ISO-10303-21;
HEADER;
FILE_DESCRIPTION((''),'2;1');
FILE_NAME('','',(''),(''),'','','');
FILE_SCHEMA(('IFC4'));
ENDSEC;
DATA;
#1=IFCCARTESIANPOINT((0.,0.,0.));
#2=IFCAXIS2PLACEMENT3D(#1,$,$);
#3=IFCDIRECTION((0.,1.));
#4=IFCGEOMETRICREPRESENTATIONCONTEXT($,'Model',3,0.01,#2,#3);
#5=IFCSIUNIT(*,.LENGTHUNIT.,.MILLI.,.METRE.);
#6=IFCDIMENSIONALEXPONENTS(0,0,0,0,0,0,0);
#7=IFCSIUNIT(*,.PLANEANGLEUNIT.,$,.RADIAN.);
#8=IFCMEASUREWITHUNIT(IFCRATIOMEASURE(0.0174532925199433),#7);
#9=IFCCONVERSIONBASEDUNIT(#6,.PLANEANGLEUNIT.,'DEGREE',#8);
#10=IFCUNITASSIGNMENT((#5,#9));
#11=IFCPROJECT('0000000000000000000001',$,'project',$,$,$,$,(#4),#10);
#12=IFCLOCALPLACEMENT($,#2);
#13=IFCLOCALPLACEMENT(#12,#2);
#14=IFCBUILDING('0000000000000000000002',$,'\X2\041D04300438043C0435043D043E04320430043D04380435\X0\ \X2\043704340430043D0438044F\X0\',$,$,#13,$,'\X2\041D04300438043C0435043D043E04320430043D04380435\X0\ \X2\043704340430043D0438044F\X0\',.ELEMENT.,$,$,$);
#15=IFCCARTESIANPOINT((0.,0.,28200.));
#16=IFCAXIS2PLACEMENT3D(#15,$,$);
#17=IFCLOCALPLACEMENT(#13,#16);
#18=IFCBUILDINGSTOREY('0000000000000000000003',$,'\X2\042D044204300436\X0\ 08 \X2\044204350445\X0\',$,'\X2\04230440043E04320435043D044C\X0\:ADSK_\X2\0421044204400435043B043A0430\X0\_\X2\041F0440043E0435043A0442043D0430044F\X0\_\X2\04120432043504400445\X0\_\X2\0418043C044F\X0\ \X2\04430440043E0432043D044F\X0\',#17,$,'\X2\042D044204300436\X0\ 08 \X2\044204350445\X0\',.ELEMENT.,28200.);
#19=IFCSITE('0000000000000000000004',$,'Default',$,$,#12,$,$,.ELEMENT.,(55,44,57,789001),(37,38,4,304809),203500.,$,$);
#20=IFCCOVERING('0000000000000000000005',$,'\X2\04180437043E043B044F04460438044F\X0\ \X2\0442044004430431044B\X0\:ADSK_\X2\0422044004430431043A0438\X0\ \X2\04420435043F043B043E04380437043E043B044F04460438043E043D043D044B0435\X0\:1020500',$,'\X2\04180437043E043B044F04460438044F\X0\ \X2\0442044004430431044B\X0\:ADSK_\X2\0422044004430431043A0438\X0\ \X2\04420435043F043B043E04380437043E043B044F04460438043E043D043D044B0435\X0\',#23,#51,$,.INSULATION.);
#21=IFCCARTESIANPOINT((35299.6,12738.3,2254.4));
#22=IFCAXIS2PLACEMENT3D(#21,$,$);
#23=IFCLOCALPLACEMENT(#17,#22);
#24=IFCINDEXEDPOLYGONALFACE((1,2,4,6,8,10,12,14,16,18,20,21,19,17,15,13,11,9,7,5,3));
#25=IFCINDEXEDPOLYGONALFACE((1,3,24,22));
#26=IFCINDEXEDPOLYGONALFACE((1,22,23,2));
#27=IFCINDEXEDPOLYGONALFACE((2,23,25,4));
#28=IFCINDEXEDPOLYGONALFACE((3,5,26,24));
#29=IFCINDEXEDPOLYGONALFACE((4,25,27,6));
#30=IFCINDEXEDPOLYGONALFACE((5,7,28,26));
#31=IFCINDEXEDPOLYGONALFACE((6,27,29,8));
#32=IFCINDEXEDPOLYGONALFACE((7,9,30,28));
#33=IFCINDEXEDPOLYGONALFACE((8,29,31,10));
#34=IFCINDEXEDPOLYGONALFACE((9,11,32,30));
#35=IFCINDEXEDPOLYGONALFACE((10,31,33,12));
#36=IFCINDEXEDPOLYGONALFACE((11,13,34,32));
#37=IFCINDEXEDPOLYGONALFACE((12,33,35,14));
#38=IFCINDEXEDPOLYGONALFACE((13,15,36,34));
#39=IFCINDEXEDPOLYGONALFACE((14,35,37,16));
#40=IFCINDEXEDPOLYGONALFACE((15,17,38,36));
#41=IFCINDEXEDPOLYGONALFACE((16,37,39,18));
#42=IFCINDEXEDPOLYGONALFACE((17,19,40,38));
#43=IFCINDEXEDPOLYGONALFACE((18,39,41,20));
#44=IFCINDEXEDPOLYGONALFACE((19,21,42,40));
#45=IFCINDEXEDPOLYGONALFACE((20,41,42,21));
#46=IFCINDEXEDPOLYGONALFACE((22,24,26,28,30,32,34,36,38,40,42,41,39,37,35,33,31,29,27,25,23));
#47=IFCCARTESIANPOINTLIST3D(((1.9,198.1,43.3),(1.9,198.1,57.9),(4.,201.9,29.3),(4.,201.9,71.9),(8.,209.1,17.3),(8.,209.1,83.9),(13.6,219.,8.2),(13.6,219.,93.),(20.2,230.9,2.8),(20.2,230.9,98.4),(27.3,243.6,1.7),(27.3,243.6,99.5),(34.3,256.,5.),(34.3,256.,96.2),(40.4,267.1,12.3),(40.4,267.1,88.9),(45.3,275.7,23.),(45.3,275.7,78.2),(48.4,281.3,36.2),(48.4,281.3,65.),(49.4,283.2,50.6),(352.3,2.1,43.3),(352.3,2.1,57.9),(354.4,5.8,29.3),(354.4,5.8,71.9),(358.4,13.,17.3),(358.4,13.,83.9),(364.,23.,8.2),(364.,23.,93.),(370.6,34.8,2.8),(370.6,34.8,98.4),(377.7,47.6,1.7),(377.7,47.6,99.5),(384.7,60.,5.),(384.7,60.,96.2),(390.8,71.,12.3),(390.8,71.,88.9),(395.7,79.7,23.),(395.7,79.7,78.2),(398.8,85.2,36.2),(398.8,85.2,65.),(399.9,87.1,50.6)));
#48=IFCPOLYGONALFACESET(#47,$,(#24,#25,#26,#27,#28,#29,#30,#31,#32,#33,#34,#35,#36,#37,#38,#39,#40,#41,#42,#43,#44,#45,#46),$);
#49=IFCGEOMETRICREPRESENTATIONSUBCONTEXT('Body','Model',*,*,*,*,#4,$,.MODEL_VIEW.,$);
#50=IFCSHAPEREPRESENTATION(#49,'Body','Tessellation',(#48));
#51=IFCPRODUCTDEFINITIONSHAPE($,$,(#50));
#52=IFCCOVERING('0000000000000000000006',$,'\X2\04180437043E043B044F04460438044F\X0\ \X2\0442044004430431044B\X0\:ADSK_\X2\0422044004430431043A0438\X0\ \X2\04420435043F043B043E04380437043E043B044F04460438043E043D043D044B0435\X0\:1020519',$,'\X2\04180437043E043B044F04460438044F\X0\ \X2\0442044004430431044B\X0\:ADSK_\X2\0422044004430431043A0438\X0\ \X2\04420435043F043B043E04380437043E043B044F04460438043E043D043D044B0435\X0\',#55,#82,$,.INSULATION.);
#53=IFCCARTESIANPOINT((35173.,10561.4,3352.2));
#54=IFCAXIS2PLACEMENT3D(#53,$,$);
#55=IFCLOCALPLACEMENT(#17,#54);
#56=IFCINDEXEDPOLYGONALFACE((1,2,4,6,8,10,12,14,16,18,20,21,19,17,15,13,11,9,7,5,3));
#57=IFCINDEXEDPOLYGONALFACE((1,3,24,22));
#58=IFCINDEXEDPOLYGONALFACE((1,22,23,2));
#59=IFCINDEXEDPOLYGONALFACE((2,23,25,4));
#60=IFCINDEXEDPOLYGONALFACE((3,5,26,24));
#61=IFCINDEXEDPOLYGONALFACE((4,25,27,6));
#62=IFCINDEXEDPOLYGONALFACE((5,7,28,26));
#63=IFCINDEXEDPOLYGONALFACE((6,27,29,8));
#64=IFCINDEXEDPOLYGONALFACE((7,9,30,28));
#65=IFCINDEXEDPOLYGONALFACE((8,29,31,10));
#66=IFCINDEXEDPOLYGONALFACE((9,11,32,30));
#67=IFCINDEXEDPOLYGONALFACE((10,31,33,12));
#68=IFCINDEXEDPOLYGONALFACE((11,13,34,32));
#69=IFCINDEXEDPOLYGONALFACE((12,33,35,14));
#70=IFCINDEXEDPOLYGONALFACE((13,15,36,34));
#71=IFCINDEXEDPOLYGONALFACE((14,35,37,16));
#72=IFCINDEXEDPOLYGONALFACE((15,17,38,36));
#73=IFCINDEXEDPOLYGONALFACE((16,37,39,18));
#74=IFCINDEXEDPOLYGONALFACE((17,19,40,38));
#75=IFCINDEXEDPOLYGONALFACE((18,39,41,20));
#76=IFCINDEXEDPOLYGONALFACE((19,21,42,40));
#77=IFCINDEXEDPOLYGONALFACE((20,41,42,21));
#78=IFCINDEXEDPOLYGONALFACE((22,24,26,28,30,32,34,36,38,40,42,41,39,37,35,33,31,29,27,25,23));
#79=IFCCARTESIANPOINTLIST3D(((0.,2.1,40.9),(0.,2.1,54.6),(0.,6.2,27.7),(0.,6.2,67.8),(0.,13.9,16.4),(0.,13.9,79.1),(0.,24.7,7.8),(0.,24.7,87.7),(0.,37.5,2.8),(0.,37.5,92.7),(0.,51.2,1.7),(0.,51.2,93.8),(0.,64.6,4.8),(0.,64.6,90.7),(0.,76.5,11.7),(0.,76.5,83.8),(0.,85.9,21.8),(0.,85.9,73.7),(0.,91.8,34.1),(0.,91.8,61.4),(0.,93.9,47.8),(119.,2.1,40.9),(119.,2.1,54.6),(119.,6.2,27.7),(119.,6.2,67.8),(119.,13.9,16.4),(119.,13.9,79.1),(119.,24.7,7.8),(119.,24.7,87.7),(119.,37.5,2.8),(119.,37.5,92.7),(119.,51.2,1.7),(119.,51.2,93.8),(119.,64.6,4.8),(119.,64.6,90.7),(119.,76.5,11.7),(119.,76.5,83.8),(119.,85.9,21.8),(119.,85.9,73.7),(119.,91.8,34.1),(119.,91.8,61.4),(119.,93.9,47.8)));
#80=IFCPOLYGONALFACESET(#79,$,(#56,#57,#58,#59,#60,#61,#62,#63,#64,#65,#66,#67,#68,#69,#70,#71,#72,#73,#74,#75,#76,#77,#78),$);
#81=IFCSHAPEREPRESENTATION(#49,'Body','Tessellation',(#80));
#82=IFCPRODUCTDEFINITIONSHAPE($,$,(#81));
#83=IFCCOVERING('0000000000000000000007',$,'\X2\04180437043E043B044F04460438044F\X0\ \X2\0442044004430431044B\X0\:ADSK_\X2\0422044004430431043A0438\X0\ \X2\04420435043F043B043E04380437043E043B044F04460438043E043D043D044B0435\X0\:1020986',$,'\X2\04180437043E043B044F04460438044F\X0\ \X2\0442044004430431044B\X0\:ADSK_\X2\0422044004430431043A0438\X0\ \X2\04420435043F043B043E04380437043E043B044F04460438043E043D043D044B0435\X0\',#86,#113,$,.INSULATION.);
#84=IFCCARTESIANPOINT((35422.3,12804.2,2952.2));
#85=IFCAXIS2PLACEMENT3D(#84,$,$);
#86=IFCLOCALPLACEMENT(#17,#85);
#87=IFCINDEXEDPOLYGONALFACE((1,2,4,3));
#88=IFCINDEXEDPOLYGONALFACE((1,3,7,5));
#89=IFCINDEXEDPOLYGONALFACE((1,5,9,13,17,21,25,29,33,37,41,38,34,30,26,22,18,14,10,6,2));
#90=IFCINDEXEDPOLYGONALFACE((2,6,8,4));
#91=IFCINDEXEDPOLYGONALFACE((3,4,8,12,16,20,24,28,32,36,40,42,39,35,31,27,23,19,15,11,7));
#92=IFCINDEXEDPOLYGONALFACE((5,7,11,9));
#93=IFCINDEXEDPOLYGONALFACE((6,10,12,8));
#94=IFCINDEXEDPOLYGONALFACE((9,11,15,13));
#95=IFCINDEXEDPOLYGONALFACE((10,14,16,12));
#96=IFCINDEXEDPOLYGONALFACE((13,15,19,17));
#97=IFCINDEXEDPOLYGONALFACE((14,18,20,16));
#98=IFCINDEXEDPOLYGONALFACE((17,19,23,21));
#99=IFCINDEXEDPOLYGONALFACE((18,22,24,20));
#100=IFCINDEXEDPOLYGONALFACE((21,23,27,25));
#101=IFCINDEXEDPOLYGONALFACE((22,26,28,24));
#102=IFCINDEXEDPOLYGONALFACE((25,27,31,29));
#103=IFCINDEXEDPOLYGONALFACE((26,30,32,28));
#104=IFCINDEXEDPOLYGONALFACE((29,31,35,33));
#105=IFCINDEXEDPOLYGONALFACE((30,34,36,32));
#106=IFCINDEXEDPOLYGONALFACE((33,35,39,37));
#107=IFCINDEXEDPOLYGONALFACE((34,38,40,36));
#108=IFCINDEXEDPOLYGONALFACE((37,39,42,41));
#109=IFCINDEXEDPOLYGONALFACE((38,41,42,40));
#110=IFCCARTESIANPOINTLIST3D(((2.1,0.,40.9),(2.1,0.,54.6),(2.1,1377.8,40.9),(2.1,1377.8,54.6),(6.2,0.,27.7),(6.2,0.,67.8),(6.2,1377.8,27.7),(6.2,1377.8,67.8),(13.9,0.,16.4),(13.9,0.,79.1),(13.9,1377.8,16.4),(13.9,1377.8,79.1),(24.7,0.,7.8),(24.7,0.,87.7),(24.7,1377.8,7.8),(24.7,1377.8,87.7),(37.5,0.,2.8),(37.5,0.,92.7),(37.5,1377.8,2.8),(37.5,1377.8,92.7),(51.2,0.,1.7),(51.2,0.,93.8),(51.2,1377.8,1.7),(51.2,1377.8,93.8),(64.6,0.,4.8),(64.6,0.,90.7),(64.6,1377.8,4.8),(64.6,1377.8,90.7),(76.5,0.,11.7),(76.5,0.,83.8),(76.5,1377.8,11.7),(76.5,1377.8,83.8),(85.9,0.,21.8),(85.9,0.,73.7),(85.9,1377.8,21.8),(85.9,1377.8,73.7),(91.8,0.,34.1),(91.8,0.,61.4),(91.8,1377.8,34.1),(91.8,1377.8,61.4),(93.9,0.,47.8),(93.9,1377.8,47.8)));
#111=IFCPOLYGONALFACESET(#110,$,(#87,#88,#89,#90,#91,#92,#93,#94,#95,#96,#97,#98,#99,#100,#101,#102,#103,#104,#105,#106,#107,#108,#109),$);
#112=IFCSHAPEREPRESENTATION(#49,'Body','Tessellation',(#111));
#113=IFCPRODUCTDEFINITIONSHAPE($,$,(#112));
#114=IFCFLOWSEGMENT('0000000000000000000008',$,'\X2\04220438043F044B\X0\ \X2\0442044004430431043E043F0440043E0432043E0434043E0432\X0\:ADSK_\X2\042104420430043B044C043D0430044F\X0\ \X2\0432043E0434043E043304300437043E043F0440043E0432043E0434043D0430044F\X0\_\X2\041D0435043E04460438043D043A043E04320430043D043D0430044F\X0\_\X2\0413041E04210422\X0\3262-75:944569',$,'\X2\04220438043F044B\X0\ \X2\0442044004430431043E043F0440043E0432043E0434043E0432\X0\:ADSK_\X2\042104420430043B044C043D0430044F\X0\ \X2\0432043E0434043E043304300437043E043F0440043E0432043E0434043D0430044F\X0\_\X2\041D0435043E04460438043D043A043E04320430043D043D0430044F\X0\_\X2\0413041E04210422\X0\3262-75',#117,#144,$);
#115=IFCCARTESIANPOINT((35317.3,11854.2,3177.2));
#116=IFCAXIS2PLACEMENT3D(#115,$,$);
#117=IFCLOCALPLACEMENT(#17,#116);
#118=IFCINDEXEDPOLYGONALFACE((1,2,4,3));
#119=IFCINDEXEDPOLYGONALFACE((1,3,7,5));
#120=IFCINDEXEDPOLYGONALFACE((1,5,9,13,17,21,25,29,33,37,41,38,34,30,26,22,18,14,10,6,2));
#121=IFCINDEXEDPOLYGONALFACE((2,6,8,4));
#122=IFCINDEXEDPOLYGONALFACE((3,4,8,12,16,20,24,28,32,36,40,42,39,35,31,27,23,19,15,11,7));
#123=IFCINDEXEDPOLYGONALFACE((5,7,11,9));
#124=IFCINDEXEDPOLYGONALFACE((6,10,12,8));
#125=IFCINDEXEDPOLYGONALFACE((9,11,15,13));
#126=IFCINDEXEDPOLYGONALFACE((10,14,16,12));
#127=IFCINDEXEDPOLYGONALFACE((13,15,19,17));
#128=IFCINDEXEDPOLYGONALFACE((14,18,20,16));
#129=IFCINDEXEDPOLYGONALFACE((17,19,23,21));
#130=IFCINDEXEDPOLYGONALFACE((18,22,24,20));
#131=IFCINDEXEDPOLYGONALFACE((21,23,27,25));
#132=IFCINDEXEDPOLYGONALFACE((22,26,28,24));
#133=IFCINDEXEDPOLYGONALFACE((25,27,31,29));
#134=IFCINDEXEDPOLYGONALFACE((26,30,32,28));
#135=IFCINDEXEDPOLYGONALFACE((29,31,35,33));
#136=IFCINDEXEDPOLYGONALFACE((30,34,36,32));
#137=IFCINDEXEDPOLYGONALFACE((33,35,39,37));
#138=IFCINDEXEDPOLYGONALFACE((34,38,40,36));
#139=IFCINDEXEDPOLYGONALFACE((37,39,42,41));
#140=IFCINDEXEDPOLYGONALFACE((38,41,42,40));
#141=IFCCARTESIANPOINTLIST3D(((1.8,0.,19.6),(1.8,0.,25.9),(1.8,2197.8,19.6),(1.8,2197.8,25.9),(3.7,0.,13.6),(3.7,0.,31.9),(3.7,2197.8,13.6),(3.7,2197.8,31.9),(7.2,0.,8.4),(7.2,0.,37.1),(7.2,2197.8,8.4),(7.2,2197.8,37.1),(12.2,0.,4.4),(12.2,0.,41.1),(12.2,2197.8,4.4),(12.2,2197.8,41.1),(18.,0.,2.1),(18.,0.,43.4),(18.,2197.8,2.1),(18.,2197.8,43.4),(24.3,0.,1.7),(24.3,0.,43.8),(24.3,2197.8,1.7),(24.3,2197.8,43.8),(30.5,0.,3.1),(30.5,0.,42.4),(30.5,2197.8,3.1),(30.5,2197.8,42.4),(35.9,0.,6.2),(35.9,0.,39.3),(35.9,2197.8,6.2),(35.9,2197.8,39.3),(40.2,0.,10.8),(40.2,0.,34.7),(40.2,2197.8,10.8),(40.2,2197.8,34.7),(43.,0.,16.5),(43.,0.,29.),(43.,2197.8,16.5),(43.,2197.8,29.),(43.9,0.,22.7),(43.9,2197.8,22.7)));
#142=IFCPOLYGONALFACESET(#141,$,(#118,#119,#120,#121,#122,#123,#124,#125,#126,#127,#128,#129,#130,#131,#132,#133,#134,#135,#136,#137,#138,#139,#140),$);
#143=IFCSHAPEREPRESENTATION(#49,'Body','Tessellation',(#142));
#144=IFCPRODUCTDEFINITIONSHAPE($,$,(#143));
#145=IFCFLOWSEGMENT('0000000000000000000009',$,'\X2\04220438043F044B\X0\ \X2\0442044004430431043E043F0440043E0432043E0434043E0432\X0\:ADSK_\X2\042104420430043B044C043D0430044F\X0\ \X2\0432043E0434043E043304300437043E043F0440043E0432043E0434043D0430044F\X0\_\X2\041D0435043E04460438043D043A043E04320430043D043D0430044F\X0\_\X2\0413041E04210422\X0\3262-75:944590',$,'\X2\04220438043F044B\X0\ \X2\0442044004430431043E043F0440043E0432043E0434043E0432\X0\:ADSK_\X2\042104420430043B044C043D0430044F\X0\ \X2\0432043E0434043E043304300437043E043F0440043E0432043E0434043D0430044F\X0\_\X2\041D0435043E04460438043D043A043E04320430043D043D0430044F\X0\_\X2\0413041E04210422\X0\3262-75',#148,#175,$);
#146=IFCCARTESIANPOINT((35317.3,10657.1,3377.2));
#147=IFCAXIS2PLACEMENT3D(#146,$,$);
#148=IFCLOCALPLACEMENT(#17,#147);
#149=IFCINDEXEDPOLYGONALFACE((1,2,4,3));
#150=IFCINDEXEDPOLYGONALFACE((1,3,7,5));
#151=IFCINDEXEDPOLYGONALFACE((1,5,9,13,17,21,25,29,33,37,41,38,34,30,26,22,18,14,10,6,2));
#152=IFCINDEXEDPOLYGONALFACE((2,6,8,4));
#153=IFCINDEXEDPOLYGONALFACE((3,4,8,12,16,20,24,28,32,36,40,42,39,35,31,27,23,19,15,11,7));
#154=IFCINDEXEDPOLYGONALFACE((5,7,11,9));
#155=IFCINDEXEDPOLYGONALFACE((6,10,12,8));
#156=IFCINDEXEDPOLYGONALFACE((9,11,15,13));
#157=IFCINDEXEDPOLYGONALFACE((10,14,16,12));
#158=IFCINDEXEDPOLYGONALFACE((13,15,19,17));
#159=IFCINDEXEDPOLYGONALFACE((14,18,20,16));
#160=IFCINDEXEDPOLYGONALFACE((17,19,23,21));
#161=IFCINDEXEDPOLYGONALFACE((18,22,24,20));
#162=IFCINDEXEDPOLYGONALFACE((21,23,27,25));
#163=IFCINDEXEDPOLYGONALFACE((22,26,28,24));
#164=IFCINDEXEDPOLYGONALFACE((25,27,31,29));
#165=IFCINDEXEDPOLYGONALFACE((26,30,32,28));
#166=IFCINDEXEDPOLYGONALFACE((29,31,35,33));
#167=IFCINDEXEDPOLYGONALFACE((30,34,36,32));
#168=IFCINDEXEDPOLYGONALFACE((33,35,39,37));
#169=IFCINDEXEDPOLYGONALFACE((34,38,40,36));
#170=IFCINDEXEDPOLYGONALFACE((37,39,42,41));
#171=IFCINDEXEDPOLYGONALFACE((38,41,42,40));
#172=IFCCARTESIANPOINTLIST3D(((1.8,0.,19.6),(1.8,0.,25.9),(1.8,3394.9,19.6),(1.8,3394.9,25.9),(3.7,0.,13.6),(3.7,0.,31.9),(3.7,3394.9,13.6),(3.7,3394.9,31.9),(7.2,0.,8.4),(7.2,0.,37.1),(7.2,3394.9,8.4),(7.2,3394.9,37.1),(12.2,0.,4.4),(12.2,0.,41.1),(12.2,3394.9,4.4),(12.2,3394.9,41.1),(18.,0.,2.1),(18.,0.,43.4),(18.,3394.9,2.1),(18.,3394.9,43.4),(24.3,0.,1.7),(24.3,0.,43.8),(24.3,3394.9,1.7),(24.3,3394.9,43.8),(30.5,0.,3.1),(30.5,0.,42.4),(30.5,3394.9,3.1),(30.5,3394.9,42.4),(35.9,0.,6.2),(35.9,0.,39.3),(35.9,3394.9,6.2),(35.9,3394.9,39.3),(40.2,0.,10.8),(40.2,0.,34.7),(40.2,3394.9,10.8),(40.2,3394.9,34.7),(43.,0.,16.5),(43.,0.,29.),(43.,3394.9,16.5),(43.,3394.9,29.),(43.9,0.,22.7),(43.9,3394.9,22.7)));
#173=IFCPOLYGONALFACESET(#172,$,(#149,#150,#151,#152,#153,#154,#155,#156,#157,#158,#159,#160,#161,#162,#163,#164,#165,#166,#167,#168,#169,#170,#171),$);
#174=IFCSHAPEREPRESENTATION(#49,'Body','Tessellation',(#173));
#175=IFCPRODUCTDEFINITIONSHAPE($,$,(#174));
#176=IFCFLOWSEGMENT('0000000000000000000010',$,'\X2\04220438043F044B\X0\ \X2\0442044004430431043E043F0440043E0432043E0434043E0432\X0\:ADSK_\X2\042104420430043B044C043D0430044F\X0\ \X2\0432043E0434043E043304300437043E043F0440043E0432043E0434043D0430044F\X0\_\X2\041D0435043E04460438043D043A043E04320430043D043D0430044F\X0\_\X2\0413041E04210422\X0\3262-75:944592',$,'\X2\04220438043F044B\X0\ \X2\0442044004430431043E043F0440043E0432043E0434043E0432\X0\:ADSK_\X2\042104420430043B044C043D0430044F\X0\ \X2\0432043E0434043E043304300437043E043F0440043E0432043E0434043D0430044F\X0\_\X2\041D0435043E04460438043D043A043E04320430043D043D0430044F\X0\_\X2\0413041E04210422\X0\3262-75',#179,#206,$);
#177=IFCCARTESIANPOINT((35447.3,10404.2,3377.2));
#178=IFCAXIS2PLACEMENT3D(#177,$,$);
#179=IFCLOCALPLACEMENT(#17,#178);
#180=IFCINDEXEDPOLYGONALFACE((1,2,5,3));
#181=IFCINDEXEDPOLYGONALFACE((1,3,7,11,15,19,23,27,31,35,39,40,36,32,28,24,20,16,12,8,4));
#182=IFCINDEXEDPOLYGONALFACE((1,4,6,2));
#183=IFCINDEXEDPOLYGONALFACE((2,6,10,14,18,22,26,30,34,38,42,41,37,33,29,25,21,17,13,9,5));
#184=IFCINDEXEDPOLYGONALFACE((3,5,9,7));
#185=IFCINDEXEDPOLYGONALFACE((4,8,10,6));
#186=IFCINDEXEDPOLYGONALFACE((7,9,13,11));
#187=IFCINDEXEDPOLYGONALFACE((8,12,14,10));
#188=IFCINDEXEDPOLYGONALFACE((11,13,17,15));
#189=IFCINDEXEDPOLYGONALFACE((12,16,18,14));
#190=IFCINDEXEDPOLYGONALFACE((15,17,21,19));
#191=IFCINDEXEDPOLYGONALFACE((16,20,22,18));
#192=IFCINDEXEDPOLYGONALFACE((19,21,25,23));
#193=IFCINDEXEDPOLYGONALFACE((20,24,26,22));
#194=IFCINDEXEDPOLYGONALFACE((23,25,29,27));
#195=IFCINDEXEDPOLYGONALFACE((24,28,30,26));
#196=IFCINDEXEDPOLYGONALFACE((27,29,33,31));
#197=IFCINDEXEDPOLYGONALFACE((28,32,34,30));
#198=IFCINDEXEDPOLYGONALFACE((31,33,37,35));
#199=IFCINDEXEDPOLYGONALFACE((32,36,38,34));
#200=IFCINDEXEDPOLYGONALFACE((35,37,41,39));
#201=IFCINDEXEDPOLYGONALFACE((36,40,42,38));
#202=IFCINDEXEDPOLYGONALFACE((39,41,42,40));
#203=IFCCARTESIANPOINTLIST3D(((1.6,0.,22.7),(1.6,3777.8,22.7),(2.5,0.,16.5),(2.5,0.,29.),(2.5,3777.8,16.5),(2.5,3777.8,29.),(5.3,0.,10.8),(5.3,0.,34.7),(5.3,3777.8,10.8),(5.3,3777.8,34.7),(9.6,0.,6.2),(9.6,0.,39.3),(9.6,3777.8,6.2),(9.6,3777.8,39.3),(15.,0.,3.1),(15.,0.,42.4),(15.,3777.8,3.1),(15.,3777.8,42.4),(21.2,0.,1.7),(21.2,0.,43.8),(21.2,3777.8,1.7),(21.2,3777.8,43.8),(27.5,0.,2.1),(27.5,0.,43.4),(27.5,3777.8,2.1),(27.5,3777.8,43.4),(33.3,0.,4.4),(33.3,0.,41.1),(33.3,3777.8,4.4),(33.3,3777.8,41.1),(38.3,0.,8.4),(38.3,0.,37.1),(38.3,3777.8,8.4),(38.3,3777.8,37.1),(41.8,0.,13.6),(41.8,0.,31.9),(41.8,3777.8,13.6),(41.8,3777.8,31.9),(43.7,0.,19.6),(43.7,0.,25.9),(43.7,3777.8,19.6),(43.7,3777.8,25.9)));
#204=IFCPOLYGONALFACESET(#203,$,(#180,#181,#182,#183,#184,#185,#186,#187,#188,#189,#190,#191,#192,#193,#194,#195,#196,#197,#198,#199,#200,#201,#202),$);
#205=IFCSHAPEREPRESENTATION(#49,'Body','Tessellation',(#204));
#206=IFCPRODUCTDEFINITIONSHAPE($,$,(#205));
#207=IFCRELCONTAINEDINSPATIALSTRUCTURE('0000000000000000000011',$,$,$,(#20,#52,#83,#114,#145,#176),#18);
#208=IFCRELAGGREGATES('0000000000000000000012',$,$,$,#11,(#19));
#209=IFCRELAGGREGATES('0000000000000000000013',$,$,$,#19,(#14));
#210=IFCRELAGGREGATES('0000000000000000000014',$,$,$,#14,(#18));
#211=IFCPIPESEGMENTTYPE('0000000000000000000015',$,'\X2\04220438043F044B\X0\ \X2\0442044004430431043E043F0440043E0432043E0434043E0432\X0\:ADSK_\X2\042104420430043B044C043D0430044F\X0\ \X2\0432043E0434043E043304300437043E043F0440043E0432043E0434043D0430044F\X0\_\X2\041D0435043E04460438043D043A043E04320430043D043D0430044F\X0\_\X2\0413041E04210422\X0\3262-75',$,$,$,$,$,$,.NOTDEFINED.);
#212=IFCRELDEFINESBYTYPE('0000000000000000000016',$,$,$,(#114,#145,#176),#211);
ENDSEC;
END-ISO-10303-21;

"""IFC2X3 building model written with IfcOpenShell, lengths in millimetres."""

from ifc_helpers import new_model, entity, si_unit, converted_unit, direction, frame, origin, origin_2d_with_axis, place, context, subcontext, project, spatial, circle, extrude, type_object, element, save


model = new_model("IFC2X3")

# Units and contexts
model_context = context("Model", 3, precision=0.01, world=origin(), true_north=direction((0.0, 1.0)))
body_context = subcontext(model_context, "Body", "Model", "MODEL_VIEW")
ifc_project = project(units=[si_unit("LENGTHUNIT", "METRE", prefix="MILLI"), converted_unit("PLANEANGLEUNIT", "DEGREE", entity("IfcRatioMeasure", 0.0174532925199433), si_unit("PLANEANGLEUNIT", "RADIAN"), dimensions=[0, 0, 0, 0, 0, 0, 0])], contexts=[model_context])

# Site, building, storey
site_placement = place(None, origin())
site = spatial("IfcSite", under=ifc_project, at=site_placement, Name="Default", CompositionType="ELEMENT", RefLatitude=(55, 44, 57, 789001), RefLongitude=(37, 38, 4, 304809), RefElevation=203500.0)
building_placement = place(site_placement, origin())
building = spatial("IfcBuilding", under=site, at=building_placement, Name="Наименование здания", LongName="Наименование здания", CompositionType="ELEMENT")
storey_placement = place(building_placement, frame((0.0, 0.0, 28200.0)))
storey = spatial("IfcBuildingStorey", under=building, at=storey_placement, Name="Этаж 08 тех", ObjectType="Уровень:ADSK_Стрелка_Проектная_Вверх_Имя уровня", LongName="Этаж 08 тех", CompositionType="ELEMENT", Elevation=28200.0)

# Coverings
covering_1_placement = place(storey_placement, frame((35299.6, 12738.3, 2254.4)))
element("IfcCovering", 1, at=covering_1_placement, inside=storey, Name="Изоляция трубы:ADSK_Трубки теплоизоляционные:1020500", ObjectType="Изоляция трубы:ADSK_Трубки теплоизоляционные", PredefinedType="INSULATION", context=body_context, shape_type="SweptSolid", body=[
    extrude(circle(Radius=49.0, at=origin_2d_with_axis()), frame((25.5, 240.4, 50.6), z_axis=(0.87271, -0.488239, 0.0), x_axis=(0.488239, 0.87271, 0.0)), (0.0, 0.0, 1.0), 401.5),
])
covering_2_placement = place(storey_placement, frame((35173.0, 10561.4, 3352.2)))
element("IfcCovering", 2, at=covering_2_placement, inside=storey, Name="Изоляция трубы:ADSK_Трубки теплоизоляционные:1020519", ObjectType="Изоляция трубы:ADSK_Трубки теплоизоляционные", PredefinedType="INSULATION", context=body_context, shape_type="SweptSolid", body=[
    extrude(circle(Radius=46.1, at=origin_2d_with_axis()), frame((0.0, 47.8, 47.8), z_axis=(1.0, 0.0, 0.0), x_axis=(0.0, 1.0, 0.0)), (0.0, 0.0, 1.0), 119.0),
])
covering_3_placement = place(storey_placement, frame((35422.3, 12804.2, 2952.2)))
element("IfcCovering", 3, at=covering_3_placement, inside=storey, Name="Изоляция трубы:ADSK_Трубки теплоизоляционные:1020986", ObjectType="Изоляция трубы:ADSK_Трубки теплоизоляционные", PredefinedType="INSULATION", context=body_context, shape_type="SweptSolid", body=[
    extrude(circle(Radius=46.1, at=origin_2d_with_axis()), frame((47.8, 0.0, 47.8), z_axis=(0.0, 1.0, 0.0), x_axis=(1.0, 0.0, 0.0)), (0.0, 0.0, 1.0), 1377.8),
])

# Flow segments
pipe_segment_type = type_object("IfcPipeSegmentType", Name="Типы трубопроводов:ADSK_Стальная водогазопроводная_Неоцинкованная_ГОСТ3262-75", PredefinedType="NOTDEFINED")
flow_segment_1_placement = place(storey_placement, frame((35317.3, 11854.2, 3177.2)))
element("IfcFlowSegment", 4, at=flow_segment_1_placement, inside=storey, type_object=pipe_segment_type, Name="Типы трубопроводов:ADSK_Стальная водогазопроводная_Неоцинкованная_ГОСТ3262-75:944569", ObjectType="Типы трубопроводов:ADSK_Стальная водогазопроводная_Неоцинкованная_ГОСТ3262-75", context=body_context, shape_type="SweptSolid", body=[
    extrude(circle(Radius=21.1, at=origin_2d_with_axis()), frame((22.8, 0.0, 22.8), z_axis=(0.0, 1.0, 0.0), x_axis=(1.0, 0.0, 0.0)), (0.0, 0.0, 1.0), 2197.8),
])
flow_segment_2_placement = place(storey_placement, frame((35317.3, 10657.1, 3377.2)))
element("IfcFlowSegment", 5, at=flow_segment_2_placement, inside=storey, type_object=pipe_segment_type, Name="Типы трубопроводов:ADSK_Стальная водогазопроводная_Неоцинкованная_ГОСТ3262-75:944590", ObjectType="Типы трубопроводов:ADSK_Стальная водогазопроводная_Неоцинкованная_ГОСТ3262-75", context=body_context, shape_type="SweptSolid", body=[
    extrude(circle(Radius=21.1, at=origin_2d_with_axis()), frame((22.8, 0.0, 22.8), z_axis=(0.0, 1.0, 0.0), x_axis=(1.0, 0.0, 0.0)), (0.0, 0.0, 1.0), 3394.9),
])
flow_segment_3_placement = place(storey_placement, frame((35447.3, 10404.2, 3377.2)))
element("IfcFlowSegment", 6, at=flow_segment_3_placement, inside=storey, type_object=pipe_segment_type, Name="Типы трубопроводов:ADSK_Стальная водогазопроводная_Неоцинкованная_ГОСТ3262-75:944592", ObjectType="Типы трубопроводов:ADSK_Стальная водогазопроводная_Неоцинкованная_ГОСТ3262-75", context=body_context, shape_type="SweptSolid", body=[
    extrude(circle(Radius=21.1, at=origin_2d_with_axis()), frame((22.8, 0.0, 22.8), z_axis=(0.0, 1.0, 0.0), x_axis=(-1.0, 0.0, 0.0)), (0.0, 0.0, 1.0), 3777.8),
])

save(model, "model.ifc")
